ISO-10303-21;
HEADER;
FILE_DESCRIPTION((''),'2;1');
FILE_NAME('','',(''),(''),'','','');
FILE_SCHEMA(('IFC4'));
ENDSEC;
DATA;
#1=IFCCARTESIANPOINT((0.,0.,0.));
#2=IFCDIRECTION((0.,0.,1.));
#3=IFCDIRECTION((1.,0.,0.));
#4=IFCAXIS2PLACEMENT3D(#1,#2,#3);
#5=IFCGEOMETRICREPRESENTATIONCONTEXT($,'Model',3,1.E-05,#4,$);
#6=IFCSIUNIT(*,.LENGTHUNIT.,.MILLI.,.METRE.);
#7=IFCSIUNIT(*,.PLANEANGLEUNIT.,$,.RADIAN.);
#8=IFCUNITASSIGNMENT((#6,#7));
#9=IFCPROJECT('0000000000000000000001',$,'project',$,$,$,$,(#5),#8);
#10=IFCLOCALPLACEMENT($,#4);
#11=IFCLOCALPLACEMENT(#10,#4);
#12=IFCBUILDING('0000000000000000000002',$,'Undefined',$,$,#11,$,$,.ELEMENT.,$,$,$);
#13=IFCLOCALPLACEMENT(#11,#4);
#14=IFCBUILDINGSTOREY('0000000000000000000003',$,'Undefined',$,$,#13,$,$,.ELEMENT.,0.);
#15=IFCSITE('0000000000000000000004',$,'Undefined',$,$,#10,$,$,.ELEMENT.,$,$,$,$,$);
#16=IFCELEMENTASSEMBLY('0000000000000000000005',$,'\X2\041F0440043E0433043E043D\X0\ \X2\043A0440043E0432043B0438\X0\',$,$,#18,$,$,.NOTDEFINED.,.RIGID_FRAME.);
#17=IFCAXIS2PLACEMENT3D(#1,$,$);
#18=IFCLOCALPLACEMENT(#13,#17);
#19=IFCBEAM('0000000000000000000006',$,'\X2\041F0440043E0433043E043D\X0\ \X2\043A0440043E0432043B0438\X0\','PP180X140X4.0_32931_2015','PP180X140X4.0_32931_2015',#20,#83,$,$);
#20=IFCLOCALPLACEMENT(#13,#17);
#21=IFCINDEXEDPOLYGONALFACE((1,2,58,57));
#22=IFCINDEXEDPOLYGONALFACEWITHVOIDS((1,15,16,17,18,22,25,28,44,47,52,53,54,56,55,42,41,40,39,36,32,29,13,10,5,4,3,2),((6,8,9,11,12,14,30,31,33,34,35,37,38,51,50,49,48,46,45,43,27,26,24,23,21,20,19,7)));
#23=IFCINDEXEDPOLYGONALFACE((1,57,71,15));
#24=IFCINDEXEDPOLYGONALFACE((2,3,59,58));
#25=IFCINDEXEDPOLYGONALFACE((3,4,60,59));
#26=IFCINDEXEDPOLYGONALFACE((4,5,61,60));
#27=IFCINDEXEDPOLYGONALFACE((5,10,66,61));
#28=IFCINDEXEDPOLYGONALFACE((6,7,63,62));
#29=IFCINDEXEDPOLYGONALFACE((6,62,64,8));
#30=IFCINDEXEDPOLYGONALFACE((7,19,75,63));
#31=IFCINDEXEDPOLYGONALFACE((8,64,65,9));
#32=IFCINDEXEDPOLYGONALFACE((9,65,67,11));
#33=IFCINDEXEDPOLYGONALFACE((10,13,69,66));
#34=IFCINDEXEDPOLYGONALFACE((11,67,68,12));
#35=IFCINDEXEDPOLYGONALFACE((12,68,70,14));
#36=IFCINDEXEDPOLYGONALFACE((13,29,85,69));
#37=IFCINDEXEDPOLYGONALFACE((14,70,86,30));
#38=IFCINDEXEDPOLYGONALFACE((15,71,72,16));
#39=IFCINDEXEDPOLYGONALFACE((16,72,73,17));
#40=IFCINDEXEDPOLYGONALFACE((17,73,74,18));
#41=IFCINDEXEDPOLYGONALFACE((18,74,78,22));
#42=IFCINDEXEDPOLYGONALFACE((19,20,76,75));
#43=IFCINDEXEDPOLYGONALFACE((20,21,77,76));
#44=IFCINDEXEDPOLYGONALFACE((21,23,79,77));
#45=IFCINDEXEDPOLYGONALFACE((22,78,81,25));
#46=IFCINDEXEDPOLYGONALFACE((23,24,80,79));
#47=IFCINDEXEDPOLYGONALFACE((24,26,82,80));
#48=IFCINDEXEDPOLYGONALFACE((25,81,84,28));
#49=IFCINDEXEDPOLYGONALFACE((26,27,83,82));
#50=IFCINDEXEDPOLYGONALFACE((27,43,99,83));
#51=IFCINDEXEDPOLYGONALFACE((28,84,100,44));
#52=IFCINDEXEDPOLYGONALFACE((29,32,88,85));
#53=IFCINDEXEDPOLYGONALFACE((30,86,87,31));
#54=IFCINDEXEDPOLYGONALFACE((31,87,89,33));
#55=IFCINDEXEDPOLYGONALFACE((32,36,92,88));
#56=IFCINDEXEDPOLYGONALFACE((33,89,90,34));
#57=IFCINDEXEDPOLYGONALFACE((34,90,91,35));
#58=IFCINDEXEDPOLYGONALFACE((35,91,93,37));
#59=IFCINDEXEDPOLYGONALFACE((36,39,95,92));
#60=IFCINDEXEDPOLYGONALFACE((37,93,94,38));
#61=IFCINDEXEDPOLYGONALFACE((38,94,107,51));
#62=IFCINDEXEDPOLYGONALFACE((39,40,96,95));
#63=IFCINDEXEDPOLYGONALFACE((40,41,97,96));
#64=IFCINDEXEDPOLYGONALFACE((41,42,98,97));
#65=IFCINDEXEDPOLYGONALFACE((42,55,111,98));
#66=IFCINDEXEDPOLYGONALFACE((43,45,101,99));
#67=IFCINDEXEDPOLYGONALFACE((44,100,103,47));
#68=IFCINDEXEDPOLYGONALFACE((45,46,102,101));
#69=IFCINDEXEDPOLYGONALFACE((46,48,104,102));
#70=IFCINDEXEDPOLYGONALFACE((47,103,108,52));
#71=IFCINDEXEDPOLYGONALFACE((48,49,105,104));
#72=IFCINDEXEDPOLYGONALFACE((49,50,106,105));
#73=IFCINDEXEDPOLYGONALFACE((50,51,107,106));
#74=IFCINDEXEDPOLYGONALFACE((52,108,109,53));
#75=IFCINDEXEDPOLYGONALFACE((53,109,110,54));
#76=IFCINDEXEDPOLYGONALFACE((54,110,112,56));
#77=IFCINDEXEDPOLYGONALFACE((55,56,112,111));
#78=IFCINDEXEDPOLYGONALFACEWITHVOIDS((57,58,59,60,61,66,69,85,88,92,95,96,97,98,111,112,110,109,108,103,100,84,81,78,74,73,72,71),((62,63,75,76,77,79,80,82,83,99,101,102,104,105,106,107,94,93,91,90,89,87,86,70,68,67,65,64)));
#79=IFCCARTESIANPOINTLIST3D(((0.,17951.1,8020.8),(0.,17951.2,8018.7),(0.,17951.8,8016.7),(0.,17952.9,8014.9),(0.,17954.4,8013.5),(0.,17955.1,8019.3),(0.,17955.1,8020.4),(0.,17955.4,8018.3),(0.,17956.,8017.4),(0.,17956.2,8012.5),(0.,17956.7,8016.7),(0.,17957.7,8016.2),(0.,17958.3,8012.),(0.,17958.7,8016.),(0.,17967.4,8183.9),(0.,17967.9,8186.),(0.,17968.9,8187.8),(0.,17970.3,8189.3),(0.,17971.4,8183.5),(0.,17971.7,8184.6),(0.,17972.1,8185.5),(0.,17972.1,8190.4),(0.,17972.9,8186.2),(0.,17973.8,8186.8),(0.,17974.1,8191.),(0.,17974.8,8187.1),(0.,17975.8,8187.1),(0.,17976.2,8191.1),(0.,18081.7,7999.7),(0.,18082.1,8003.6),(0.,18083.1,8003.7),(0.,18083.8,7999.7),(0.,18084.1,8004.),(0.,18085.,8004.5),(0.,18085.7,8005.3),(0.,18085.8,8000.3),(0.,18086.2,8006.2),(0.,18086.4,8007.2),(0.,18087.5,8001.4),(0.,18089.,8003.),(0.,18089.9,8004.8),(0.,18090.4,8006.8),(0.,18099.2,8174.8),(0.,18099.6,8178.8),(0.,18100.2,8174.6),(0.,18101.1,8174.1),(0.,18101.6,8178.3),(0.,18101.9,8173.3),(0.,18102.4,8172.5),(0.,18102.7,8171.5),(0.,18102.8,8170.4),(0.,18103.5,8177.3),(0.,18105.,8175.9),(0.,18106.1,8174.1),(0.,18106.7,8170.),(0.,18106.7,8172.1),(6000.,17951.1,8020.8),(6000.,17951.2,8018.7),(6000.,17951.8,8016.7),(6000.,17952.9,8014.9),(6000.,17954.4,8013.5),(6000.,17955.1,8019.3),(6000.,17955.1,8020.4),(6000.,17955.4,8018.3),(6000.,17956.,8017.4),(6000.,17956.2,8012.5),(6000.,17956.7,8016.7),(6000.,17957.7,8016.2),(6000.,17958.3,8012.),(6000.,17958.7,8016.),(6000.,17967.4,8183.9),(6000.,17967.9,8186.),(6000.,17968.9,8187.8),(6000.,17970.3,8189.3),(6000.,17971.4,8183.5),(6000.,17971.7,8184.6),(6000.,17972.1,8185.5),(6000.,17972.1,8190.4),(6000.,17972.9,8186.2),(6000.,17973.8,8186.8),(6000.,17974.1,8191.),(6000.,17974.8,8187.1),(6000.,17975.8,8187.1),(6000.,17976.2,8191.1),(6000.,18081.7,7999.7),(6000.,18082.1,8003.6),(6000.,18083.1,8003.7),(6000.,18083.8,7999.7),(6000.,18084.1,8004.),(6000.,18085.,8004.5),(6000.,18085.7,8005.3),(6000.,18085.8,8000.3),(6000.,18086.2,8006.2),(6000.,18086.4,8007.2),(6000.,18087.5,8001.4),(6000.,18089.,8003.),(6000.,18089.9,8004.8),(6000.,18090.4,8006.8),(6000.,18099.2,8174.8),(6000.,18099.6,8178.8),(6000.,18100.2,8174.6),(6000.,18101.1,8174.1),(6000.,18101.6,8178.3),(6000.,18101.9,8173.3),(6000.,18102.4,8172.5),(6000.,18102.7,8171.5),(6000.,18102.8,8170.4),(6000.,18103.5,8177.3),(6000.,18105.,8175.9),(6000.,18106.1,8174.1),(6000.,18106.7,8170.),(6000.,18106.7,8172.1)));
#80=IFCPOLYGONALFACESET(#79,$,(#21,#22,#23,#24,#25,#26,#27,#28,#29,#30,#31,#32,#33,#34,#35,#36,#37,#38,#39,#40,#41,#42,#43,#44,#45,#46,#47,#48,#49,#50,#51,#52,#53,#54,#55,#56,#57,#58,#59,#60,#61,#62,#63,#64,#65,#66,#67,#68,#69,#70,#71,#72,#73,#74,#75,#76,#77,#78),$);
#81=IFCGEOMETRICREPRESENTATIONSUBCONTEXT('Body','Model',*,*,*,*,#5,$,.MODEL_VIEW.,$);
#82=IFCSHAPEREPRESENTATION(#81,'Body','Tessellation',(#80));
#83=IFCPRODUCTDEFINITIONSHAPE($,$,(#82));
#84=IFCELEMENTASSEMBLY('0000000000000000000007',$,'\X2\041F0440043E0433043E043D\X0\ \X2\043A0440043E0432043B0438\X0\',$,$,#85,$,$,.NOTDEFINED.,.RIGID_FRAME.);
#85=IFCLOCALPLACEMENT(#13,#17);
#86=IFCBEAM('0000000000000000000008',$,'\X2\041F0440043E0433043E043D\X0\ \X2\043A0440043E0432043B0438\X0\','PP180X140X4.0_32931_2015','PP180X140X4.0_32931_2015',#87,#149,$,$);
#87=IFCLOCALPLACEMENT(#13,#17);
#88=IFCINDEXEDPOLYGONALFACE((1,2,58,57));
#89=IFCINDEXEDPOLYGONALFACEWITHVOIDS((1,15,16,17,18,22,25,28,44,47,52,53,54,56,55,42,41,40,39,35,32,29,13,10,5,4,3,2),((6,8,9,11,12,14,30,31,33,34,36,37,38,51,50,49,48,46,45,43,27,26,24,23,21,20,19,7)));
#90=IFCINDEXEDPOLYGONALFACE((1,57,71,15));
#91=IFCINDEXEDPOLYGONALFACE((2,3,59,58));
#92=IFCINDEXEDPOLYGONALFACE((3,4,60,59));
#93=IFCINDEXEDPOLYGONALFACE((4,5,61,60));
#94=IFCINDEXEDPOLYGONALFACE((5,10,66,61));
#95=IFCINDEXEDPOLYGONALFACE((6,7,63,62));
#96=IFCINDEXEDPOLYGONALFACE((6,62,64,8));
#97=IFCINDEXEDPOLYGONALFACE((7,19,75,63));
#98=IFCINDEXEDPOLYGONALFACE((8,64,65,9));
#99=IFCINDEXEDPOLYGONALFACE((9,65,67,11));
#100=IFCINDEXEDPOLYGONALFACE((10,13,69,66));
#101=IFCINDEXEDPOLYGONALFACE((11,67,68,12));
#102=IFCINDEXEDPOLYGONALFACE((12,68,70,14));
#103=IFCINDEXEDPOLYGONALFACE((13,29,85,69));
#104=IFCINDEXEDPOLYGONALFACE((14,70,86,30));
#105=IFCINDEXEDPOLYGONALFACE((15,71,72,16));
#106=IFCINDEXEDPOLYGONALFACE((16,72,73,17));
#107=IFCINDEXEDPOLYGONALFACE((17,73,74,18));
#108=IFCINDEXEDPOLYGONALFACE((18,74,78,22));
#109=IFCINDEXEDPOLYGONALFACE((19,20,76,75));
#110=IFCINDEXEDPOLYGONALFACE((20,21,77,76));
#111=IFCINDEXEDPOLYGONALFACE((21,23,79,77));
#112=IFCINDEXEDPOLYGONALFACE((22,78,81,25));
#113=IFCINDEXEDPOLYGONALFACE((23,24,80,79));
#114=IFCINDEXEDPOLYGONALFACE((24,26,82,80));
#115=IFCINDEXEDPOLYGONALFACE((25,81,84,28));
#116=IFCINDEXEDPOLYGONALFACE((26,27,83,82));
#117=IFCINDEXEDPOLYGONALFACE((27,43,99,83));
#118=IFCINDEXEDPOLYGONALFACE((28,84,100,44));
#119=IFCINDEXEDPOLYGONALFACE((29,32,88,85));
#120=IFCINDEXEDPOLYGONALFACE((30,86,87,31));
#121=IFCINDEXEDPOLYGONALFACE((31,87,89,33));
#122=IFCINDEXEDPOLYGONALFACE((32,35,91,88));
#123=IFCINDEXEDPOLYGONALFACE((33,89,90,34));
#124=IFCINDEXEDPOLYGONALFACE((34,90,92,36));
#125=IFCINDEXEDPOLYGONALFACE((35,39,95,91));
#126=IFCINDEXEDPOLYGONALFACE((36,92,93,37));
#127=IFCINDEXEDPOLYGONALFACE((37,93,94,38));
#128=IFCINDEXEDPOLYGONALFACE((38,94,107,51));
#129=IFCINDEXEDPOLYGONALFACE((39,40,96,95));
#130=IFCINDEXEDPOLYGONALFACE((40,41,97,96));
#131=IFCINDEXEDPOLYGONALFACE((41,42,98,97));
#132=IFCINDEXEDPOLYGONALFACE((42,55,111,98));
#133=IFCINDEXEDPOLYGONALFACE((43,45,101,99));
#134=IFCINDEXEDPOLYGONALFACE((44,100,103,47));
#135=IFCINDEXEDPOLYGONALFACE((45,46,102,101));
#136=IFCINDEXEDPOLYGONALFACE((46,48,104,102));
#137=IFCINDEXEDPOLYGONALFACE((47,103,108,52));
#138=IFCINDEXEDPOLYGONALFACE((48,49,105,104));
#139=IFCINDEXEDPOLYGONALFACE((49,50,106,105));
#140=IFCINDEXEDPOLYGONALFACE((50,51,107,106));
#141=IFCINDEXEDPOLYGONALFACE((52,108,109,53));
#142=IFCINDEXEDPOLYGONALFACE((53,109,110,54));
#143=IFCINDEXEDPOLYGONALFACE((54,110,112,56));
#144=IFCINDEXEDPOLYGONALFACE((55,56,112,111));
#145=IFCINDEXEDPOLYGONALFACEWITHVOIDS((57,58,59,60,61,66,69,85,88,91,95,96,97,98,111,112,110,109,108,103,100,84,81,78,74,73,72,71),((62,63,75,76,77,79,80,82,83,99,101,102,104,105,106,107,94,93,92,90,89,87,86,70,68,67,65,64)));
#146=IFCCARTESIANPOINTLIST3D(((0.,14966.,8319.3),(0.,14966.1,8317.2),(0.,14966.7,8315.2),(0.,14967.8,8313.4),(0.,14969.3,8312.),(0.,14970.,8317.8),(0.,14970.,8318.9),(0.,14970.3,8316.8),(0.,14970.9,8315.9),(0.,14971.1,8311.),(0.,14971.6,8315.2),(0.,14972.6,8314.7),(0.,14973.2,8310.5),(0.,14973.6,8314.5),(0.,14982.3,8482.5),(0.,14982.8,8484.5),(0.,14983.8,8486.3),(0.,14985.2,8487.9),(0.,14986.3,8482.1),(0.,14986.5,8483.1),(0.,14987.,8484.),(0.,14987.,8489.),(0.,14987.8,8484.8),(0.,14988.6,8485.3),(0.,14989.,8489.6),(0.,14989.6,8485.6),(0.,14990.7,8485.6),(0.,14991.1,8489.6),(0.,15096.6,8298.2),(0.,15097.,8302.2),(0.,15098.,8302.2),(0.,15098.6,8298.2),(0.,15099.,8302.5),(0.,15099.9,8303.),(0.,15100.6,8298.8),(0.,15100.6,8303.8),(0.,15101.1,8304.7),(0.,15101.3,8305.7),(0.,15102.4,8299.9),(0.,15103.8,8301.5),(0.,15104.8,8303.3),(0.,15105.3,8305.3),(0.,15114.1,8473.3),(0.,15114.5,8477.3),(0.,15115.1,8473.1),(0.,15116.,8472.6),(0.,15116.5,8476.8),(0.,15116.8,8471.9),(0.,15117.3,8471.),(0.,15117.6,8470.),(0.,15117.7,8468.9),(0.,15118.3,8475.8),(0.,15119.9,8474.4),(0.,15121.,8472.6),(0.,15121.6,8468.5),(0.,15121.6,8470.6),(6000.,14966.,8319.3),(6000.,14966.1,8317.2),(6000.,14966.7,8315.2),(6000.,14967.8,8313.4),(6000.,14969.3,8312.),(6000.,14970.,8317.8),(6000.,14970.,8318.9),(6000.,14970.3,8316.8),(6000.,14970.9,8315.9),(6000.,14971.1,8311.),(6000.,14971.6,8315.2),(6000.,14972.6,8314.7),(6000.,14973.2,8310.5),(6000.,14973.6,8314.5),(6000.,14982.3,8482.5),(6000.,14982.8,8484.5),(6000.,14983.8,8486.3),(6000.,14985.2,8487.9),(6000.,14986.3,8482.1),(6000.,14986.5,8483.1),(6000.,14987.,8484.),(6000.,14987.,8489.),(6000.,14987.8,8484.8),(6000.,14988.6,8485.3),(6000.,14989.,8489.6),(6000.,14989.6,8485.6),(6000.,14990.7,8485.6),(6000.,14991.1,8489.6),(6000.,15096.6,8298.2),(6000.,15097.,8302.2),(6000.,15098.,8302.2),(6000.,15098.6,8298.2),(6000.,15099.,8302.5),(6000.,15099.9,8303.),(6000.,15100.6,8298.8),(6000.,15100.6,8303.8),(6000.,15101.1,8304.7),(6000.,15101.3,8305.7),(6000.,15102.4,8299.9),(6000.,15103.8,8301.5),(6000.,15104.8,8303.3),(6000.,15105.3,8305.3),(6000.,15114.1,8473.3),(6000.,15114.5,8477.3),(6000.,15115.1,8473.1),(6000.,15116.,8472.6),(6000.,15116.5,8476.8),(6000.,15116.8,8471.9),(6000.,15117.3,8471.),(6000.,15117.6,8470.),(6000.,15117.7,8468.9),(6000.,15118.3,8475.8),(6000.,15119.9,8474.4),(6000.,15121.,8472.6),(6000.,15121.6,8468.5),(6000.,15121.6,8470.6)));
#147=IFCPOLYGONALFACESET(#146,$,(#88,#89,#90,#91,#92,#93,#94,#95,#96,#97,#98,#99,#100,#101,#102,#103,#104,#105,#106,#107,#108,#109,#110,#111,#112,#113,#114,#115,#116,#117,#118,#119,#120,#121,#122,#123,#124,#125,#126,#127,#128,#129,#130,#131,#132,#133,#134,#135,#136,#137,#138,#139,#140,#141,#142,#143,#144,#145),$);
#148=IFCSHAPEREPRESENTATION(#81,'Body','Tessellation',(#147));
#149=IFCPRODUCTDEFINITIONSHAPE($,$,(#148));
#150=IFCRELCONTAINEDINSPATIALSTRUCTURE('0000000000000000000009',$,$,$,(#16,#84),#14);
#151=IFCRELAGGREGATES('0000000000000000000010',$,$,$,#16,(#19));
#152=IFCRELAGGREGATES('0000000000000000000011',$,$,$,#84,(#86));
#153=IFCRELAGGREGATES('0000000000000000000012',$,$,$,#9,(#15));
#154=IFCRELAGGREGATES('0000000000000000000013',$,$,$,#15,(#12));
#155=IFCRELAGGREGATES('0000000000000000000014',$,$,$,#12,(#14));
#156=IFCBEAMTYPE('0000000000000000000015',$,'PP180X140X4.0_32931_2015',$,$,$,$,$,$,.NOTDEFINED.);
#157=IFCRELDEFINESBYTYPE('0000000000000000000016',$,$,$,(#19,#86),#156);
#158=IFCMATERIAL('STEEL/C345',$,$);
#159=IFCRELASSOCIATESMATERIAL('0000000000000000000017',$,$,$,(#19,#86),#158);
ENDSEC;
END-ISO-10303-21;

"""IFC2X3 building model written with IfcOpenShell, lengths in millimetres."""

from ifc_helpers import new_model, si_unit, frame, origin_with_axes, origin_2d_with_axis, place, context, subcontext, project, spatial, hollow_rectangle, extrude, material, type_object, element, aggregate, save


model = new_model("IFC2X3")

# Units and contexts
model_context = context("Model", 3, precision=1e-05, world=origin_with_axes())
body_context = subcontext(model_context, "Body", "Model", "MODEL_VIEW")
ifc_project = project(units=[si_unit("LENGTHUNIT", "METRE", prefix="MILLI"), si_unit("PLANEANGLEUNIT", "RADIAN")], contexts=[model_context])

# Site, building, storey
site_placement = place(None, origin_with_axes())
site = spatial("IfcSite", under=ifc_project, at=site_placement, Name="Undefined", CompositionType="ELEMENT")
building_placement = place(site_placement, origin_with_axes())
building = spatial("IfcBuilding", under=site, at=building_placement, Name="Undefined", CompositionType="ELEMENT")
storey_placement = place(building_placement, origin_with_axes())
storey = spatial("IfcBuildingStorey", under=building, at=storey_placement, Name="Undefined", CompositionType="ELEMENT", Elevation=0.0)

# Shared definitions
ifc_material_1 = material(Name="STEEL/C345")

# Element assemblies, beams
beam_type_1 = type_object("IfcBeamType", Name="PP180X140X4.0_32931_2015", PredefinedType="NOTDEFINED")
assembly_1_placement = place(storey_placement, origin_with_axes())
assembly_1 = element("IfcElementAssembly", 1, at=assembly_1_placement, inside=storey, Name="Прогон кровли", AssemblyPlace="NOTDEFINED", PredefinedType="RIGID_FRAME")
beam_1_placement = place(assembly_1_placement, frame((0.0, 18028.9, 8095.4), z_axis=(0.0, 0.099504, 0.995037), x_axis=(1.0, 0.0, 0.0)))
beam_1 = element("IfcBeam", 2, at=beam_1_placement, type_object=beam_type_1, material=ifc_material_1, Name="Прогон кровли", Description="PP180X140X4.0_32931_2015", ObjectType="PP180X140X4.0_32931_2015", context=body_context, shape_type="SweptSolid", body=[
    extrude(hollow_rectangle(XDim=140.0, YDim=180.0, WallThickness=4.0, InnerFilletRadius=4.0, OuterFilletRadius=8.0, at=origin_2d_with_axis()), frame((6000.0, 0.0, 0.0), z_axis=(-1.0, 0.0, 0.0), x_axis=(0.0, -1.0, 0.0)), (0.0, 0.0, 1.0), 6000.0),
])
aggregate(assembly_1, [beam_1])
assembly_2_placement = place(storey_placement, origin_with_axes())
assembly_2 = element("IfcElementAssembly", 3, at=assembly_2_placement, inside=storey, Name="Прогон кровли", AssemblyPlace="NOTDEFINED", PredefinedType="RIGID_FRAME")
beam_2_placement = place(assembly_2_placement, frame((0.0, 15043.8, 8393.9), z_axis=(0.0, 0.099504, 0.995037), x_axis=(1.0, 0.0, 0.0)))
beam_2 = element("IfcBeam", 4, at=beam_2_placement, type_object=beam_type_1, material=ifc_material_1, Name="Прогон кровли", Description="PP180X140X4.0_32931_2015", ObjectType="PP180X140X4.0_32931_2015", context=body_context, shape_type="SweptSolid", body=[
    extrude(hollow_rectangle(XDim=140.0, YDim=180.0, WallThickness=4.0, InnerFilletRadius=4.0, OuterFilletRadius=8.0, at=origin_2d_with_axis()), frame((6000.0, 0.0, 0.0), z_axis=(-1.0, 0.0, 0.0), x_axis=(0.0, -1.0, 0.0)), (0.0, 0.0, 1.0), 6000.0),
])
aggregate(assembly_2, [beam_2])

save(model, "model.ifc")
